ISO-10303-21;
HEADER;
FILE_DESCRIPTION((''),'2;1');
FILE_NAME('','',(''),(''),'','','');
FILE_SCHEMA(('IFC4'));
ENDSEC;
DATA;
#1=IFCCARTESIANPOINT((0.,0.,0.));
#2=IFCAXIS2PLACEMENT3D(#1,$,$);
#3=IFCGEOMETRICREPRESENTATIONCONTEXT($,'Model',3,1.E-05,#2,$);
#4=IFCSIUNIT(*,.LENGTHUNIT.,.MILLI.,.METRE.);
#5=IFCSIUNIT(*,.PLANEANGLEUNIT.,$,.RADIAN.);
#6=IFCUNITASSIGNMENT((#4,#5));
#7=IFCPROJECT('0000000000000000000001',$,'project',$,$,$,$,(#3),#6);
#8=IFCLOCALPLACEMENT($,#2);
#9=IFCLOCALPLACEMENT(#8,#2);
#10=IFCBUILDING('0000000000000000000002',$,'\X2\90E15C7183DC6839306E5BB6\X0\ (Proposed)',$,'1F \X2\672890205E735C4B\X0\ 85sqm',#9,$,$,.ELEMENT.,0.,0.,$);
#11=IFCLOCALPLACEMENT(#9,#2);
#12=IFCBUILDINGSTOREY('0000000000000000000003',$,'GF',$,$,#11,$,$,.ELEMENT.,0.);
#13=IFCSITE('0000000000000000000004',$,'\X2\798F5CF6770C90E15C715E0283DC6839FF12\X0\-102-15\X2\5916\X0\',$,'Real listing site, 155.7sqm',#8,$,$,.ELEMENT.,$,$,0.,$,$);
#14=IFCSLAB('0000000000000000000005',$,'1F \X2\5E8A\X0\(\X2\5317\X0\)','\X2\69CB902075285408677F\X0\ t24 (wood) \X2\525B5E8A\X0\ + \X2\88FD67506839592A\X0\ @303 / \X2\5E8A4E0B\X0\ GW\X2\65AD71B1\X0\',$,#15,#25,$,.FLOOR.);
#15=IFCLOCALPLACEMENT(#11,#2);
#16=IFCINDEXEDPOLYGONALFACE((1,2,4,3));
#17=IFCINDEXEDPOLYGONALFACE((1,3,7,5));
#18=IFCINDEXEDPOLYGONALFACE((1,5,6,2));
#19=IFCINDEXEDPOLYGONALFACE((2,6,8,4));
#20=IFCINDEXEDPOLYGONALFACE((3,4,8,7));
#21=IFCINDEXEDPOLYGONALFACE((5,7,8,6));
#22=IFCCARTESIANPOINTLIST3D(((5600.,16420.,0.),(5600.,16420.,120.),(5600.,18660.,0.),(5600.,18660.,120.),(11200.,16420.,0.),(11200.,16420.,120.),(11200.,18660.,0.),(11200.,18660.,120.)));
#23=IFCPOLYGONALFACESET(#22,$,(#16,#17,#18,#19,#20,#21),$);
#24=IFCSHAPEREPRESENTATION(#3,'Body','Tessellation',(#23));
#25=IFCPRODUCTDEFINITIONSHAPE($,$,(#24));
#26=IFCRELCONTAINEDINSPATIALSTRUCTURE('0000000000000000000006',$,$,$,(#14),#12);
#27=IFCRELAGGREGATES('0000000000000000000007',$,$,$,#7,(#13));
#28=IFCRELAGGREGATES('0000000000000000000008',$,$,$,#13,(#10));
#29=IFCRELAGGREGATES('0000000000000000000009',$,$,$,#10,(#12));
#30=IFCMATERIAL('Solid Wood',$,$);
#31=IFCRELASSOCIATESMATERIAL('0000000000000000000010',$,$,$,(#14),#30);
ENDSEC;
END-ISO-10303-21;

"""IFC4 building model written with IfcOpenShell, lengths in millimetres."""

from ifc_helpers import new_model, si_unit, frame, frame_2d, origin, place, context, project, spatial, rectangle, extrude, material, element, save


model = new_model("IFC4")

# Units and contexts
model_context = context("Model", 3, precision=1e-05, world=origin())
ifc_project = project(units=[si_unit("LENGTHUNIT", "METRE", prefix="MILLI"), si_unit("PLANEANGLEUNIT", "RADIAN")], contexts=[model_context])

# Site, building, storey
site_placement = place(None, origin())
site = spatial("IfcSite", under=ifc_project, at=site_placement, Name="福島県郡山市菜根２-102-15外", ObjectType="Real listing site, 155.7sqm", CompositionType="ELEMENT", RefElevation=0.0)
building_placement = place(site_placement, origin())
building = spatial("IfcBuilding", under=site, at=building_placement, Name="郡山菜根の家 (Proposed)", ObjectType="1F 木造平屋 85sqm", CompositionType="ELEMENT", ElevationOfRefHeight=0.0, ElevationOfTerrain=0.0)
storey_placement = place(building_placement, origin())
storey = spatial("IfcBuildingStorey", under=building, at=storey_placement, Name="GF", CompositionType="ELEMENT", Elevation=0.0)

# Slab
ifc_material_1 = material(Name="Solid Wood")
slab_1_placement = place(storey_placement, frame((2800.0, 8210.0, 0.0)))
element("IfcSlab", 1, at=slab_1_placement, inside=storey, material=ifc_material_1, Name="1F 床(北)", Description="構造用合板 t24 (wood) 剛床 + 製材根太 @303 / 床下 GW断熱", PredefinedType="FLOOR", context=model_context, shape_type="SweptSolid", body=[
    extrude(rectangle(XDim=5600.0, YDim=2240.0, at=frame_2d((2800.0, 1120.0))), frame((2800.0, 8210.0, 0.0)), (0.0, 0.0, 1.0), 120.0),
])

save(model, "model.ifc")
